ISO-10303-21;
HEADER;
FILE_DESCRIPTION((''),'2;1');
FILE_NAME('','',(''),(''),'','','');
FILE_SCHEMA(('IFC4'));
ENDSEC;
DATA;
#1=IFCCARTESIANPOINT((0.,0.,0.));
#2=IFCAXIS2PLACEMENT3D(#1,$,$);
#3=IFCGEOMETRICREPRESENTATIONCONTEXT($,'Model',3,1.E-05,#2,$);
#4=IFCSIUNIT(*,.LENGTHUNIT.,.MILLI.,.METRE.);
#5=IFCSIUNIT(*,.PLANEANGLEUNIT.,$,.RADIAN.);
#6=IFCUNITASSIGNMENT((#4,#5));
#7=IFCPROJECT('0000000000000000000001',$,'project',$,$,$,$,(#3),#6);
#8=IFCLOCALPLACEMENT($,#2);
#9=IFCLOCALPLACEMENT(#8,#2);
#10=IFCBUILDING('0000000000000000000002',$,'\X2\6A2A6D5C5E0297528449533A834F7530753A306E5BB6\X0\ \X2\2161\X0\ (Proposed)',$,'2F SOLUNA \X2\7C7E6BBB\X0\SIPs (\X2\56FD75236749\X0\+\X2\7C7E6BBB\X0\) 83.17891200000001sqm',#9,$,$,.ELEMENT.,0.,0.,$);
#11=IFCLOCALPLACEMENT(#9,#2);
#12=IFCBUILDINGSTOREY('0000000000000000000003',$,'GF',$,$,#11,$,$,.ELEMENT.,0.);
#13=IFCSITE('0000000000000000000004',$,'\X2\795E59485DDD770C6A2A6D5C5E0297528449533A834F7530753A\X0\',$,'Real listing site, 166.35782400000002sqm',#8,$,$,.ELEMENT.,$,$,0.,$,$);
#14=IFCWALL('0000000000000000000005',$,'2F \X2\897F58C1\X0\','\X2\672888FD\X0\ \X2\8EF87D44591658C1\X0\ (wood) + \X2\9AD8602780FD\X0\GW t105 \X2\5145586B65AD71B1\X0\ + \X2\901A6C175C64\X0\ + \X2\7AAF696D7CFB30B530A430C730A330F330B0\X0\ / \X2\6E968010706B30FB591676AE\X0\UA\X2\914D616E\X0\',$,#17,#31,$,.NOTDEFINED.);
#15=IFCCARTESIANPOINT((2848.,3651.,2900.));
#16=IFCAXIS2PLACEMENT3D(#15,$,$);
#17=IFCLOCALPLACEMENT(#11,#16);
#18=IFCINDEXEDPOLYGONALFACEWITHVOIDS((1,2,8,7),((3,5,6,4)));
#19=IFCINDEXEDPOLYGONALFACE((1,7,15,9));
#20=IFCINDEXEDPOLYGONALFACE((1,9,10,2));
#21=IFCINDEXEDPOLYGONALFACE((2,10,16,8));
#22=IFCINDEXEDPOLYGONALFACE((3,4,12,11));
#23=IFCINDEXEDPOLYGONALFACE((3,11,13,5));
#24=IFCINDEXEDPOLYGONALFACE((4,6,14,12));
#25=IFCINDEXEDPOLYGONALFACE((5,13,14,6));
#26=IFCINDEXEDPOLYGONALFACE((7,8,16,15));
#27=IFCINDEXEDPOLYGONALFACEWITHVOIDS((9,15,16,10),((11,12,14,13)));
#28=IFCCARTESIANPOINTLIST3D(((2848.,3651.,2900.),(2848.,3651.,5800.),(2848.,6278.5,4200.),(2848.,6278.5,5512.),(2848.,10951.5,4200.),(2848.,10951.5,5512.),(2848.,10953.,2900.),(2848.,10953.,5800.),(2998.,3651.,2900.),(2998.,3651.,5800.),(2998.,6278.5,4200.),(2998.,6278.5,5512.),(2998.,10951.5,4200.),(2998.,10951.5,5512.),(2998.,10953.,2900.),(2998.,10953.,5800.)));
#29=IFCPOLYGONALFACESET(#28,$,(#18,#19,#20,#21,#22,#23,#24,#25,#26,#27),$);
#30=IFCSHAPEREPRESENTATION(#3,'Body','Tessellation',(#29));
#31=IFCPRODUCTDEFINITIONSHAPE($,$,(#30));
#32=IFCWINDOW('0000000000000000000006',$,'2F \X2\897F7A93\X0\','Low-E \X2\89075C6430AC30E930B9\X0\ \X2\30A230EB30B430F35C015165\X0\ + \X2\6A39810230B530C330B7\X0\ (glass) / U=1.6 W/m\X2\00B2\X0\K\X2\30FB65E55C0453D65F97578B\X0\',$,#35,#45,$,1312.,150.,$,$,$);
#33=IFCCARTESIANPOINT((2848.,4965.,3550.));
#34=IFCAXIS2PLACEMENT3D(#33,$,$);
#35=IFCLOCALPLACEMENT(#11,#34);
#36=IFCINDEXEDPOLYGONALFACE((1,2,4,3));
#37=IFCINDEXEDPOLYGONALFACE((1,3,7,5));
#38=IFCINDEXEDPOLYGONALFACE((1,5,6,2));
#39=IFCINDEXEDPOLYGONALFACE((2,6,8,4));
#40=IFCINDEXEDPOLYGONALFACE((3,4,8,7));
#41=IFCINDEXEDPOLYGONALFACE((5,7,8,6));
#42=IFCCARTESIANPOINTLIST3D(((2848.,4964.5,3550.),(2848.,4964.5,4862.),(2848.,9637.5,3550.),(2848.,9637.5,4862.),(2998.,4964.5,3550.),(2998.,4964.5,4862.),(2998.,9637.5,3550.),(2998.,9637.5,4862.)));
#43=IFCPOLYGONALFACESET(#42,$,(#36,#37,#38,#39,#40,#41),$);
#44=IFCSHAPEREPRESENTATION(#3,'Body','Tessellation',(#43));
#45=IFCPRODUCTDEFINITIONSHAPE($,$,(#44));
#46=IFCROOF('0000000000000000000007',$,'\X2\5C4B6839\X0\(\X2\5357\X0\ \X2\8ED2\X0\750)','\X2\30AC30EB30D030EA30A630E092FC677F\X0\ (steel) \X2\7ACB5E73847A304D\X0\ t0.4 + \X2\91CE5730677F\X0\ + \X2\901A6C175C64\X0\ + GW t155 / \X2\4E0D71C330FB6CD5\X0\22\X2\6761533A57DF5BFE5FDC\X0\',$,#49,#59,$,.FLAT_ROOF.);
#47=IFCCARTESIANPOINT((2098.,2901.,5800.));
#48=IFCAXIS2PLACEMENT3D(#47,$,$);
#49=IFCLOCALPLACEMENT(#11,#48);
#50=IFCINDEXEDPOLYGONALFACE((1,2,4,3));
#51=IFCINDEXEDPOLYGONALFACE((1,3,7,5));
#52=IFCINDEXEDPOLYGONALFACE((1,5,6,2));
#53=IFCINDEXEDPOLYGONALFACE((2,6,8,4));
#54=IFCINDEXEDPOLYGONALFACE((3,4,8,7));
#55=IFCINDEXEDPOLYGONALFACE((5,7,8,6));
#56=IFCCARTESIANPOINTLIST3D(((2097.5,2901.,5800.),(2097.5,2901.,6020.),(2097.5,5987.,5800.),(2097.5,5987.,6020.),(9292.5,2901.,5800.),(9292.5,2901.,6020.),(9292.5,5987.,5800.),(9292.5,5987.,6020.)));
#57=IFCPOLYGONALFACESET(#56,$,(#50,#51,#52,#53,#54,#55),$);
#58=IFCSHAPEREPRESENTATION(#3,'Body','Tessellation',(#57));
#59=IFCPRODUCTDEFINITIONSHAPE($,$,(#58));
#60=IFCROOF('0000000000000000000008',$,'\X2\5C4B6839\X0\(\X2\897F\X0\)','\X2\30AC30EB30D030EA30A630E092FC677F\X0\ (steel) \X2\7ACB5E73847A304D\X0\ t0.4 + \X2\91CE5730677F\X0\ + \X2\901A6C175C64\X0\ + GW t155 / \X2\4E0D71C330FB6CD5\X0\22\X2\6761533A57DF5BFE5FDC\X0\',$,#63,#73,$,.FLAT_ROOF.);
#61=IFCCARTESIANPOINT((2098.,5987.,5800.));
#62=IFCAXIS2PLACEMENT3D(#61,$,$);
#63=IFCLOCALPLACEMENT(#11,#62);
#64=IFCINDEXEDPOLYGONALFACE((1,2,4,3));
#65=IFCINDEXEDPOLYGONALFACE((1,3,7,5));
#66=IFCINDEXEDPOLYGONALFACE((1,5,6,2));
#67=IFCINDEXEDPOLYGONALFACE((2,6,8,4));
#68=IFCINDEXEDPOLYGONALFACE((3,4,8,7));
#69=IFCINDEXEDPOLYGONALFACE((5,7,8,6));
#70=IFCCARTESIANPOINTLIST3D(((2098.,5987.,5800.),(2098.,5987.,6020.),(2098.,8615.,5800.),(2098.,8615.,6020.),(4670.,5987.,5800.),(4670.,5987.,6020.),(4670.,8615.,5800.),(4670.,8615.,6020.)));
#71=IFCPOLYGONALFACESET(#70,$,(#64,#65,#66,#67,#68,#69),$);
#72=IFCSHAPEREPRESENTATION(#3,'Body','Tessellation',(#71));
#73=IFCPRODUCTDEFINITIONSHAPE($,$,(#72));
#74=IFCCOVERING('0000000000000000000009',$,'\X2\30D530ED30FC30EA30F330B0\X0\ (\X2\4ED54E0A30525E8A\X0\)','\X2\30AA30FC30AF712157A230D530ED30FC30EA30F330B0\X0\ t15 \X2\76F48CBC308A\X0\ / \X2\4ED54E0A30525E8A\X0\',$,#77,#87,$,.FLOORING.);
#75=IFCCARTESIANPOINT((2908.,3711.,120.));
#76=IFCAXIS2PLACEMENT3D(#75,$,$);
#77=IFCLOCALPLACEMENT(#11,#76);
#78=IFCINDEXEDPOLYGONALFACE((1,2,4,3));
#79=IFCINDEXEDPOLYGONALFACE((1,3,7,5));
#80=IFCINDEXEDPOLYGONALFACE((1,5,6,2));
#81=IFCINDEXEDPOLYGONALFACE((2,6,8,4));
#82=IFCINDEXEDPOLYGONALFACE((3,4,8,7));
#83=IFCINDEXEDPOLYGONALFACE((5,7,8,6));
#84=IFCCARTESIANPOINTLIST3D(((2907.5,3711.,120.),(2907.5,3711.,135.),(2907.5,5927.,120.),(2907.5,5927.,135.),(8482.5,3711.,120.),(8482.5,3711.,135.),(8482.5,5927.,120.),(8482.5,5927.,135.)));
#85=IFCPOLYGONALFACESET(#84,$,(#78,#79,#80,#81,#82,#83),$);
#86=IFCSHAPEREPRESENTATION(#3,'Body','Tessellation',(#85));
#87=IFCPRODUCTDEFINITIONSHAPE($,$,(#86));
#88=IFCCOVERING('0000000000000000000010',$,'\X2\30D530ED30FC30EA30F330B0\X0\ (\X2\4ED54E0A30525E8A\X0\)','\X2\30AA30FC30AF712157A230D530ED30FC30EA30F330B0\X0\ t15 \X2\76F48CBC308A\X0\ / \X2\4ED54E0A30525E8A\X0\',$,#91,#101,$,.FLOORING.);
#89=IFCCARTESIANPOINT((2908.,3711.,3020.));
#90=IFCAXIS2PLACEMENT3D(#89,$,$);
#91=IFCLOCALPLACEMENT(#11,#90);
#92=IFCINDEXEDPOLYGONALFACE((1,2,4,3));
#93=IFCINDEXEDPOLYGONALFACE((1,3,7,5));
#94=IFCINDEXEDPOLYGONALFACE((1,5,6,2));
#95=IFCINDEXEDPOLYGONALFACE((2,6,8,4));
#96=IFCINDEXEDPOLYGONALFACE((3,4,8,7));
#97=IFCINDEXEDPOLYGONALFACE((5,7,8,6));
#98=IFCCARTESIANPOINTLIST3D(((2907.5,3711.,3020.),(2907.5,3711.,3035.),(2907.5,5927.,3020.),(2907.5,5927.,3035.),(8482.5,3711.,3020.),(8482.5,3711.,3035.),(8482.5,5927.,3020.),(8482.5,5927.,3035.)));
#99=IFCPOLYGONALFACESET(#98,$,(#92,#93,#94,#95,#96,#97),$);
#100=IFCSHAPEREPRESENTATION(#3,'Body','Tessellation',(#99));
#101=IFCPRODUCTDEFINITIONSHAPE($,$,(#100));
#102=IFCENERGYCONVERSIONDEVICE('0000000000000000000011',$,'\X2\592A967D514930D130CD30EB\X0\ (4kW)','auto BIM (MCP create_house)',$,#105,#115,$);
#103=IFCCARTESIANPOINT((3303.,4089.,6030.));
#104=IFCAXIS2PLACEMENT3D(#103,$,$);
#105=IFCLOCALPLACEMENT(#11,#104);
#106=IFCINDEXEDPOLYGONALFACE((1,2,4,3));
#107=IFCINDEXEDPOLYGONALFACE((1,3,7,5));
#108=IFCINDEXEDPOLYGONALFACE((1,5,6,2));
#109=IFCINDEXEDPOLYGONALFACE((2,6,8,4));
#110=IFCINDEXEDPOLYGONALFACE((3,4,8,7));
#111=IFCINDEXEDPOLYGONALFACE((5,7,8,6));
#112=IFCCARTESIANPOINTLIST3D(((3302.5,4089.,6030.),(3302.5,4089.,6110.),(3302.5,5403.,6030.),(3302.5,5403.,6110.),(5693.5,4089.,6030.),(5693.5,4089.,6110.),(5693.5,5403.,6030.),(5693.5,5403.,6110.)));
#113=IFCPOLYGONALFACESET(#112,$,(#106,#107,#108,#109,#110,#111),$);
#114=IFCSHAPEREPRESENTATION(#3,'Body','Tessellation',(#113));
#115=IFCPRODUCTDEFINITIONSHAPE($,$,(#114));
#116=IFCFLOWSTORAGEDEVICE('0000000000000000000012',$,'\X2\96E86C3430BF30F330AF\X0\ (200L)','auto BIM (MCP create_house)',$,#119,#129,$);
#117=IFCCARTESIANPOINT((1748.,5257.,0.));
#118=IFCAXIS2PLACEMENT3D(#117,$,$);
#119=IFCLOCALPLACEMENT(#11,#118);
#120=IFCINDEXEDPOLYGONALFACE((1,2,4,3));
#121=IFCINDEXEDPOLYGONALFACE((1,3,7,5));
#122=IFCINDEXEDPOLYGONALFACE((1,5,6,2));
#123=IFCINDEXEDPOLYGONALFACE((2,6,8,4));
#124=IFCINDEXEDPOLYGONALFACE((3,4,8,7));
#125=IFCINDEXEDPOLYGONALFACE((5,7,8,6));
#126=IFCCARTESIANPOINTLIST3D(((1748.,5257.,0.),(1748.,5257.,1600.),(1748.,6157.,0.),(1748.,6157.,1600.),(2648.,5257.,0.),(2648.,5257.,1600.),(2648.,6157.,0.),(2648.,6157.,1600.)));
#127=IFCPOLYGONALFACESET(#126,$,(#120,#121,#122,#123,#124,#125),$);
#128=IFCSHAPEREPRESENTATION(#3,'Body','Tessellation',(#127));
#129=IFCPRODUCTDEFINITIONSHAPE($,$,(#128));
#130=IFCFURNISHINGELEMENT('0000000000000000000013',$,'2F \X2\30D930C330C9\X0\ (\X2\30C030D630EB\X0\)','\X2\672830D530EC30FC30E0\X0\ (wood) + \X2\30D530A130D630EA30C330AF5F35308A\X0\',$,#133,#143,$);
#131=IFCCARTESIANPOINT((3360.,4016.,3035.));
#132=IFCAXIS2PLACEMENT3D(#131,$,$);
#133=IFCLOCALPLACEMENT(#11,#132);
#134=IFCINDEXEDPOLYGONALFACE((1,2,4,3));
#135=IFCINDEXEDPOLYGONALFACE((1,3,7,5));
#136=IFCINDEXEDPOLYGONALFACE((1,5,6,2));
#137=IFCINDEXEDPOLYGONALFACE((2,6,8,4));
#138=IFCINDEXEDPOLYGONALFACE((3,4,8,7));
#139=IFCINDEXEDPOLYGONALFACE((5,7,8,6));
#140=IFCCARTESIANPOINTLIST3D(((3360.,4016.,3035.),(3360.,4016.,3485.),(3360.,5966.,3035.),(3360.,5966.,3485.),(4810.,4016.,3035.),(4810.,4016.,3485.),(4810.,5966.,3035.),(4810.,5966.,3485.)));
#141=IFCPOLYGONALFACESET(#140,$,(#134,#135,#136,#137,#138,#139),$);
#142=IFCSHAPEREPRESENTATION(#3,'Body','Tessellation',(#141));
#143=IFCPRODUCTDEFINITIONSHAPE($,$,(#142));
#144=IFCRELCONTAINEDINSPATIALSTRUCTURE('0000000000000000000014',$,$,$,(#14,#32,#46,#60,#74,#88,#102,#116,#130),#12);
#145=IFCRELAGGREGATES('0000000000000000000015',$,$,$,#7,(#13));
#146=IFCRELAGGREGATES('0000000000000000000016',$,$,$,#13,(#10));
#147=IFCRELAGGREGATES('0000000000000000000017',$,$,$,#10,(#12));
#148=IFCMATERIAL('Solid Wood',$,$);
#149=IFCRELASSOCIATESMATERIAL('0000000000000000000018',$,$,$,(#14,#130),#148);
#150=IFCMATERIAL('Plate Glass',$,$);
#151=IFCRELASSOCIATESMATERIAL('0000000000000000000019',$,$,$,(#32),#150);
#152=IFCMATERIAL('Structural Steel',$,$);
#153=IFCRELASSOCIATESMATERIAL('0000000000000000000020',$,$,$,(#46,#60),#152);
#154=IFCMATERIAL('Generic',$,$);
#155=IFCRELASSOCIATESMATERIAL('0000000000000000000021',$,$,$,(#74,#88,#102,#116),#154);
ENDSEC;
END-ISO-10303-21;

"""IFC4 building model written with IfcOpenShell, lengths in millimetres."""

from ifc_helpers import new_model, si_unit, frame, frame_2d, origin, place, context, project, spatial, rectangle, extrude, material, element, fill, save


model = new_model("IFC4")

# Units and contexts
model_context = context("Model", 3, precision=1e-05, world=origin())
ifc_project = project(units=[si_unit("LENGTHUNIT", "METRE", prefix="MILLI"), si_unit("PLANEANGLEUNIT", "RADIAN")], contexts=[model_context])

# Site, building, storey
site_placement = place(None, origin())
site = spatial("IfcSite", under=ifc_project, at=site_placement, Name="神奈川県横浜市青葉区荏田町", ObjectType="Real listing site, 166.35782400000002sqm", CompositionType="ELEMENT", RefElevation=0.0)
building_placement = place(site_placement, origin())
building = spatial("IfcBuilding", under=site, at=building_placement, Name="横浜市青葉区荏田町の家 Ⅱ (Proposed)", ObjectType="2F SOLUNA 籾殻SIPs (国産杉+籾殻) 83.17891200000001sqm", CompositionType="ELEMENT", ElevationOfRefHeight=0.0, ElevationOfTerrain=0.0)
storey_placement = place(building_placement, origin())
storey = spatial("IfcBuildingStorey", under=building, at=storey_placement, Name="GF", CompositionType="ELEMENT", Elevation=0.0)

# Shared definitions
ifc_material_1 = material(Name="Solid Wood")

# Shared definitions
ifc_material_2 = material(Name="Plate Glass")

# Wall, opening, window
wall_1_placement = place(storey_placement, frame((2848.0, 3651.0, 2900.0)))
wall_1 = element("IfcWall", 1, at=wall_1_placement, inside=storey, material=ifc_material_1, Name="2F 西壁", Description="木製 軸組外壁 (wood) + 高性能GW t105 充填断熱 + 通気層 + 窯業系サイディング / 準耐火・外皮UA配慮", PredefinedType="NOTDEFINED", context=model_context, shape_type="SweptSolid", body=[
    extrude(rectangle(XDim=150.0, YDim=7302.0, at=frame_2d((75.0, 3651.0))), frame((2848.0, 3651.0, 2900.0)), (0.0, 0.0, 1.0), 2900.0),
])
opening_1_placement = place(storey_placement, frame((2848.0, 4965.0, 3550.0)))
opening_1 = element("IfcOpeningElement", 2, at=opening_1_placement, cuts=wall_1, PredefinedType="NOTDEFINED", context=model_context, shape_type="SweptSolid", body=[
    extrude(rectangle(XDim=150.0, YDim=4673.0, at=frame_2d((75.0, 2336.0))), frame((2848.0, 4965.0, 3550.0)), (0.0, 0.0, 1.0), 1312.0),
])
window_1_placement = place(storey_placement, frame((2848.0, 4965.0, 3550.0)))
window_1 = element("IfcWindow", 3, at=window_1_placement, inside=storey, material=ifc_material_2, Name="2F 西窓", Description="Low-E 複層ガラス アルゴン封入 + 樹脂サッシ (glass) / U=1.6 W/m²K・日射取得型", OverallHeight=1312.0, OverallWidth=150.0, context=model_context, shape_type="SweptSolid", body=[
    extrude(rectangle(XDim=150.0, YDim=4673.0, at=frame_2d((75.0, 2336.0))), frame((2848.0, 4965.0, 3550.0)), (0.0, 0.0, 1.0), 1312.0),
])
fill(opening_1, window_1)

# Roofs
ifc_material_3 = material(Name="Structural Steel")
roof_1_placement = place(storey_placement, frame((2098.0, 2901.0, 5800.0)))
element("IfcRoof", 4, at=roof_1_placement, inside=storey, material=ifc_material_3, Name="屋根(南 軒750)", Description="ガルバリウム鋼板 (steel) 立平葺き t0.4 + 野地板 + 通気層 + GW t155 / 不燃・法22条区域対応", PredefinedType="FLAT_ROOF", context=model_context, shape_type="SweptSolid", body=[
    extrude(rectangle(XDim=7195.0, YDim=3086.0, at=frame_2d((3597.0, 1543.0))), frame((2098.0, 2901.0, 5800.0)), (0.0, 0.0, 1.0), 220.0),
])
roof_2_placement = place(storey_placement, frame((2098.0, 5987.0, 5800.0)))
element("IfcRoof", 5, at=roof_2_placement, inside=storey, material=ifc_material_3, Name="屋根(西)", Description="ガルバリウム鋼板 (steel) 立平葺き t0.4 + 野地板 + 通気層 + GW t155 / 不燃・法22条区域対応", PredefinedType="FLAT_ROOF", context=model_context, shape_type="SweptSolid", body=[
    extrude(rectangle(XDim=2572.0, YDim=2628.0, at=frame_2d((1286.0, 1314.0))), frame((2098.0, 5987.0, 5800.0)), (0.0, 0.0, 1.0), 220.0),
])

# Coverings
ifc_material_4 = material(Name="Generic")
covering_1_placement = place(storey_placement, frame((2908.0, 3711.0, 120.0)))
element("IfcCovering", 6, at=covering_1_placement, inside=storey, material=ifc_material_4, Name="フローリング (仕上げ床)", Description="オーク無垢フローリング t15 直貼り / 仕上げ床", PredefinedType="FLOORING", context=model_context, shape_type="SweptSolid", body=[
    extrude(rectangle(XDim=5575.0, YDim=2216.0, at=frame_2d((2787.0, 1108.0))), frame((2908.0, 3711.0, 120.0)), (0.0, 0.0, 1.0), 15.0),
])
covering_2_placement = place(storey_placement, frame((2908.0, 3711.0, 3020.0)))
element("IfcCovering", 7, at=covering_2_placement, inside=storey, material=ifc_material_4, Name="フローリング (仕上げ床)", Description="オーク無垢フローリング t15 直貼り / 仕上げ床", PredefinedType="FLOORING", context=model_context, shape_type="SweptSolid", body=[
    extrude(rectangle(XDim=5575.0, YDim=2216.0, at=frame_2d((2787.0, 1108.0))), frame((2908.0, 3711.0, 3020.0)), (0.0, 0.0, 1.0), 15.0),
])

# Energy conversion device
energy_conversion_device_placement = place(storey_placement, frame((3303.0, 4089.0, 6030.0)))
element("IfcEnergyConversionDevice", 8, at=energy_conversion_device_placement, inside=storey, material=ifc_material_4, Name="太陽光パネル (4kW)", Description="auto BIM (MCP create_house)", context=model_context, shape_type="SweptSolid", body=[
    extrude(rectangle(XDim=2391.0, YDim=1314.0, at=frame_2d((1195.0, 657.0))), frame((3303.0, 4089.0, 6030.0)), (0.0, 0.0, 1.0), 80.0),
])

# Flow storage device
flow_storage_device_placement = place(storey_placement, frame((1748.0, 5257.0, 0.0)))
element("IfcFlowStorageDevice", 9, at=flow_storage_device_placement, inside=storey, material=ifc_material_4, Name="雨水タンク (200L)", Description="auto BIM (MCP create_house)", context=model_context, shape_type="SweptSolid", body=[
    extrude(rectangle(XDim=900.0, YDim=900.0, at=frame_2d((450.0, 450.0))), frame((1748.0, 5257.0, 0.0)), (0.0, 0.0, 1.0), 1600.0),
])

# Furnishing element
furnishing_placement = place(storey_placement, frame((3360.0, 4016.0, 3035.0)))
element("IfcFurnishingElement", 10, at=furnishing_placement, inside=storey, material=ifc_material_1, Name="2F ベッド (ダブル)", Description="木フレーム (wood) + ファブリック張り", context=model_context, shape_type="SweptSolid", body=[
    extrude(rectangle(XDim=1450.0, YDim=1950.0, at=frame_2d((725.0, 975.0))), frame((3360.0, 4016.0, 3035.0)), (0.0, 0.0, 1.0), 450.0),
])

save(model, "model.ifc")
